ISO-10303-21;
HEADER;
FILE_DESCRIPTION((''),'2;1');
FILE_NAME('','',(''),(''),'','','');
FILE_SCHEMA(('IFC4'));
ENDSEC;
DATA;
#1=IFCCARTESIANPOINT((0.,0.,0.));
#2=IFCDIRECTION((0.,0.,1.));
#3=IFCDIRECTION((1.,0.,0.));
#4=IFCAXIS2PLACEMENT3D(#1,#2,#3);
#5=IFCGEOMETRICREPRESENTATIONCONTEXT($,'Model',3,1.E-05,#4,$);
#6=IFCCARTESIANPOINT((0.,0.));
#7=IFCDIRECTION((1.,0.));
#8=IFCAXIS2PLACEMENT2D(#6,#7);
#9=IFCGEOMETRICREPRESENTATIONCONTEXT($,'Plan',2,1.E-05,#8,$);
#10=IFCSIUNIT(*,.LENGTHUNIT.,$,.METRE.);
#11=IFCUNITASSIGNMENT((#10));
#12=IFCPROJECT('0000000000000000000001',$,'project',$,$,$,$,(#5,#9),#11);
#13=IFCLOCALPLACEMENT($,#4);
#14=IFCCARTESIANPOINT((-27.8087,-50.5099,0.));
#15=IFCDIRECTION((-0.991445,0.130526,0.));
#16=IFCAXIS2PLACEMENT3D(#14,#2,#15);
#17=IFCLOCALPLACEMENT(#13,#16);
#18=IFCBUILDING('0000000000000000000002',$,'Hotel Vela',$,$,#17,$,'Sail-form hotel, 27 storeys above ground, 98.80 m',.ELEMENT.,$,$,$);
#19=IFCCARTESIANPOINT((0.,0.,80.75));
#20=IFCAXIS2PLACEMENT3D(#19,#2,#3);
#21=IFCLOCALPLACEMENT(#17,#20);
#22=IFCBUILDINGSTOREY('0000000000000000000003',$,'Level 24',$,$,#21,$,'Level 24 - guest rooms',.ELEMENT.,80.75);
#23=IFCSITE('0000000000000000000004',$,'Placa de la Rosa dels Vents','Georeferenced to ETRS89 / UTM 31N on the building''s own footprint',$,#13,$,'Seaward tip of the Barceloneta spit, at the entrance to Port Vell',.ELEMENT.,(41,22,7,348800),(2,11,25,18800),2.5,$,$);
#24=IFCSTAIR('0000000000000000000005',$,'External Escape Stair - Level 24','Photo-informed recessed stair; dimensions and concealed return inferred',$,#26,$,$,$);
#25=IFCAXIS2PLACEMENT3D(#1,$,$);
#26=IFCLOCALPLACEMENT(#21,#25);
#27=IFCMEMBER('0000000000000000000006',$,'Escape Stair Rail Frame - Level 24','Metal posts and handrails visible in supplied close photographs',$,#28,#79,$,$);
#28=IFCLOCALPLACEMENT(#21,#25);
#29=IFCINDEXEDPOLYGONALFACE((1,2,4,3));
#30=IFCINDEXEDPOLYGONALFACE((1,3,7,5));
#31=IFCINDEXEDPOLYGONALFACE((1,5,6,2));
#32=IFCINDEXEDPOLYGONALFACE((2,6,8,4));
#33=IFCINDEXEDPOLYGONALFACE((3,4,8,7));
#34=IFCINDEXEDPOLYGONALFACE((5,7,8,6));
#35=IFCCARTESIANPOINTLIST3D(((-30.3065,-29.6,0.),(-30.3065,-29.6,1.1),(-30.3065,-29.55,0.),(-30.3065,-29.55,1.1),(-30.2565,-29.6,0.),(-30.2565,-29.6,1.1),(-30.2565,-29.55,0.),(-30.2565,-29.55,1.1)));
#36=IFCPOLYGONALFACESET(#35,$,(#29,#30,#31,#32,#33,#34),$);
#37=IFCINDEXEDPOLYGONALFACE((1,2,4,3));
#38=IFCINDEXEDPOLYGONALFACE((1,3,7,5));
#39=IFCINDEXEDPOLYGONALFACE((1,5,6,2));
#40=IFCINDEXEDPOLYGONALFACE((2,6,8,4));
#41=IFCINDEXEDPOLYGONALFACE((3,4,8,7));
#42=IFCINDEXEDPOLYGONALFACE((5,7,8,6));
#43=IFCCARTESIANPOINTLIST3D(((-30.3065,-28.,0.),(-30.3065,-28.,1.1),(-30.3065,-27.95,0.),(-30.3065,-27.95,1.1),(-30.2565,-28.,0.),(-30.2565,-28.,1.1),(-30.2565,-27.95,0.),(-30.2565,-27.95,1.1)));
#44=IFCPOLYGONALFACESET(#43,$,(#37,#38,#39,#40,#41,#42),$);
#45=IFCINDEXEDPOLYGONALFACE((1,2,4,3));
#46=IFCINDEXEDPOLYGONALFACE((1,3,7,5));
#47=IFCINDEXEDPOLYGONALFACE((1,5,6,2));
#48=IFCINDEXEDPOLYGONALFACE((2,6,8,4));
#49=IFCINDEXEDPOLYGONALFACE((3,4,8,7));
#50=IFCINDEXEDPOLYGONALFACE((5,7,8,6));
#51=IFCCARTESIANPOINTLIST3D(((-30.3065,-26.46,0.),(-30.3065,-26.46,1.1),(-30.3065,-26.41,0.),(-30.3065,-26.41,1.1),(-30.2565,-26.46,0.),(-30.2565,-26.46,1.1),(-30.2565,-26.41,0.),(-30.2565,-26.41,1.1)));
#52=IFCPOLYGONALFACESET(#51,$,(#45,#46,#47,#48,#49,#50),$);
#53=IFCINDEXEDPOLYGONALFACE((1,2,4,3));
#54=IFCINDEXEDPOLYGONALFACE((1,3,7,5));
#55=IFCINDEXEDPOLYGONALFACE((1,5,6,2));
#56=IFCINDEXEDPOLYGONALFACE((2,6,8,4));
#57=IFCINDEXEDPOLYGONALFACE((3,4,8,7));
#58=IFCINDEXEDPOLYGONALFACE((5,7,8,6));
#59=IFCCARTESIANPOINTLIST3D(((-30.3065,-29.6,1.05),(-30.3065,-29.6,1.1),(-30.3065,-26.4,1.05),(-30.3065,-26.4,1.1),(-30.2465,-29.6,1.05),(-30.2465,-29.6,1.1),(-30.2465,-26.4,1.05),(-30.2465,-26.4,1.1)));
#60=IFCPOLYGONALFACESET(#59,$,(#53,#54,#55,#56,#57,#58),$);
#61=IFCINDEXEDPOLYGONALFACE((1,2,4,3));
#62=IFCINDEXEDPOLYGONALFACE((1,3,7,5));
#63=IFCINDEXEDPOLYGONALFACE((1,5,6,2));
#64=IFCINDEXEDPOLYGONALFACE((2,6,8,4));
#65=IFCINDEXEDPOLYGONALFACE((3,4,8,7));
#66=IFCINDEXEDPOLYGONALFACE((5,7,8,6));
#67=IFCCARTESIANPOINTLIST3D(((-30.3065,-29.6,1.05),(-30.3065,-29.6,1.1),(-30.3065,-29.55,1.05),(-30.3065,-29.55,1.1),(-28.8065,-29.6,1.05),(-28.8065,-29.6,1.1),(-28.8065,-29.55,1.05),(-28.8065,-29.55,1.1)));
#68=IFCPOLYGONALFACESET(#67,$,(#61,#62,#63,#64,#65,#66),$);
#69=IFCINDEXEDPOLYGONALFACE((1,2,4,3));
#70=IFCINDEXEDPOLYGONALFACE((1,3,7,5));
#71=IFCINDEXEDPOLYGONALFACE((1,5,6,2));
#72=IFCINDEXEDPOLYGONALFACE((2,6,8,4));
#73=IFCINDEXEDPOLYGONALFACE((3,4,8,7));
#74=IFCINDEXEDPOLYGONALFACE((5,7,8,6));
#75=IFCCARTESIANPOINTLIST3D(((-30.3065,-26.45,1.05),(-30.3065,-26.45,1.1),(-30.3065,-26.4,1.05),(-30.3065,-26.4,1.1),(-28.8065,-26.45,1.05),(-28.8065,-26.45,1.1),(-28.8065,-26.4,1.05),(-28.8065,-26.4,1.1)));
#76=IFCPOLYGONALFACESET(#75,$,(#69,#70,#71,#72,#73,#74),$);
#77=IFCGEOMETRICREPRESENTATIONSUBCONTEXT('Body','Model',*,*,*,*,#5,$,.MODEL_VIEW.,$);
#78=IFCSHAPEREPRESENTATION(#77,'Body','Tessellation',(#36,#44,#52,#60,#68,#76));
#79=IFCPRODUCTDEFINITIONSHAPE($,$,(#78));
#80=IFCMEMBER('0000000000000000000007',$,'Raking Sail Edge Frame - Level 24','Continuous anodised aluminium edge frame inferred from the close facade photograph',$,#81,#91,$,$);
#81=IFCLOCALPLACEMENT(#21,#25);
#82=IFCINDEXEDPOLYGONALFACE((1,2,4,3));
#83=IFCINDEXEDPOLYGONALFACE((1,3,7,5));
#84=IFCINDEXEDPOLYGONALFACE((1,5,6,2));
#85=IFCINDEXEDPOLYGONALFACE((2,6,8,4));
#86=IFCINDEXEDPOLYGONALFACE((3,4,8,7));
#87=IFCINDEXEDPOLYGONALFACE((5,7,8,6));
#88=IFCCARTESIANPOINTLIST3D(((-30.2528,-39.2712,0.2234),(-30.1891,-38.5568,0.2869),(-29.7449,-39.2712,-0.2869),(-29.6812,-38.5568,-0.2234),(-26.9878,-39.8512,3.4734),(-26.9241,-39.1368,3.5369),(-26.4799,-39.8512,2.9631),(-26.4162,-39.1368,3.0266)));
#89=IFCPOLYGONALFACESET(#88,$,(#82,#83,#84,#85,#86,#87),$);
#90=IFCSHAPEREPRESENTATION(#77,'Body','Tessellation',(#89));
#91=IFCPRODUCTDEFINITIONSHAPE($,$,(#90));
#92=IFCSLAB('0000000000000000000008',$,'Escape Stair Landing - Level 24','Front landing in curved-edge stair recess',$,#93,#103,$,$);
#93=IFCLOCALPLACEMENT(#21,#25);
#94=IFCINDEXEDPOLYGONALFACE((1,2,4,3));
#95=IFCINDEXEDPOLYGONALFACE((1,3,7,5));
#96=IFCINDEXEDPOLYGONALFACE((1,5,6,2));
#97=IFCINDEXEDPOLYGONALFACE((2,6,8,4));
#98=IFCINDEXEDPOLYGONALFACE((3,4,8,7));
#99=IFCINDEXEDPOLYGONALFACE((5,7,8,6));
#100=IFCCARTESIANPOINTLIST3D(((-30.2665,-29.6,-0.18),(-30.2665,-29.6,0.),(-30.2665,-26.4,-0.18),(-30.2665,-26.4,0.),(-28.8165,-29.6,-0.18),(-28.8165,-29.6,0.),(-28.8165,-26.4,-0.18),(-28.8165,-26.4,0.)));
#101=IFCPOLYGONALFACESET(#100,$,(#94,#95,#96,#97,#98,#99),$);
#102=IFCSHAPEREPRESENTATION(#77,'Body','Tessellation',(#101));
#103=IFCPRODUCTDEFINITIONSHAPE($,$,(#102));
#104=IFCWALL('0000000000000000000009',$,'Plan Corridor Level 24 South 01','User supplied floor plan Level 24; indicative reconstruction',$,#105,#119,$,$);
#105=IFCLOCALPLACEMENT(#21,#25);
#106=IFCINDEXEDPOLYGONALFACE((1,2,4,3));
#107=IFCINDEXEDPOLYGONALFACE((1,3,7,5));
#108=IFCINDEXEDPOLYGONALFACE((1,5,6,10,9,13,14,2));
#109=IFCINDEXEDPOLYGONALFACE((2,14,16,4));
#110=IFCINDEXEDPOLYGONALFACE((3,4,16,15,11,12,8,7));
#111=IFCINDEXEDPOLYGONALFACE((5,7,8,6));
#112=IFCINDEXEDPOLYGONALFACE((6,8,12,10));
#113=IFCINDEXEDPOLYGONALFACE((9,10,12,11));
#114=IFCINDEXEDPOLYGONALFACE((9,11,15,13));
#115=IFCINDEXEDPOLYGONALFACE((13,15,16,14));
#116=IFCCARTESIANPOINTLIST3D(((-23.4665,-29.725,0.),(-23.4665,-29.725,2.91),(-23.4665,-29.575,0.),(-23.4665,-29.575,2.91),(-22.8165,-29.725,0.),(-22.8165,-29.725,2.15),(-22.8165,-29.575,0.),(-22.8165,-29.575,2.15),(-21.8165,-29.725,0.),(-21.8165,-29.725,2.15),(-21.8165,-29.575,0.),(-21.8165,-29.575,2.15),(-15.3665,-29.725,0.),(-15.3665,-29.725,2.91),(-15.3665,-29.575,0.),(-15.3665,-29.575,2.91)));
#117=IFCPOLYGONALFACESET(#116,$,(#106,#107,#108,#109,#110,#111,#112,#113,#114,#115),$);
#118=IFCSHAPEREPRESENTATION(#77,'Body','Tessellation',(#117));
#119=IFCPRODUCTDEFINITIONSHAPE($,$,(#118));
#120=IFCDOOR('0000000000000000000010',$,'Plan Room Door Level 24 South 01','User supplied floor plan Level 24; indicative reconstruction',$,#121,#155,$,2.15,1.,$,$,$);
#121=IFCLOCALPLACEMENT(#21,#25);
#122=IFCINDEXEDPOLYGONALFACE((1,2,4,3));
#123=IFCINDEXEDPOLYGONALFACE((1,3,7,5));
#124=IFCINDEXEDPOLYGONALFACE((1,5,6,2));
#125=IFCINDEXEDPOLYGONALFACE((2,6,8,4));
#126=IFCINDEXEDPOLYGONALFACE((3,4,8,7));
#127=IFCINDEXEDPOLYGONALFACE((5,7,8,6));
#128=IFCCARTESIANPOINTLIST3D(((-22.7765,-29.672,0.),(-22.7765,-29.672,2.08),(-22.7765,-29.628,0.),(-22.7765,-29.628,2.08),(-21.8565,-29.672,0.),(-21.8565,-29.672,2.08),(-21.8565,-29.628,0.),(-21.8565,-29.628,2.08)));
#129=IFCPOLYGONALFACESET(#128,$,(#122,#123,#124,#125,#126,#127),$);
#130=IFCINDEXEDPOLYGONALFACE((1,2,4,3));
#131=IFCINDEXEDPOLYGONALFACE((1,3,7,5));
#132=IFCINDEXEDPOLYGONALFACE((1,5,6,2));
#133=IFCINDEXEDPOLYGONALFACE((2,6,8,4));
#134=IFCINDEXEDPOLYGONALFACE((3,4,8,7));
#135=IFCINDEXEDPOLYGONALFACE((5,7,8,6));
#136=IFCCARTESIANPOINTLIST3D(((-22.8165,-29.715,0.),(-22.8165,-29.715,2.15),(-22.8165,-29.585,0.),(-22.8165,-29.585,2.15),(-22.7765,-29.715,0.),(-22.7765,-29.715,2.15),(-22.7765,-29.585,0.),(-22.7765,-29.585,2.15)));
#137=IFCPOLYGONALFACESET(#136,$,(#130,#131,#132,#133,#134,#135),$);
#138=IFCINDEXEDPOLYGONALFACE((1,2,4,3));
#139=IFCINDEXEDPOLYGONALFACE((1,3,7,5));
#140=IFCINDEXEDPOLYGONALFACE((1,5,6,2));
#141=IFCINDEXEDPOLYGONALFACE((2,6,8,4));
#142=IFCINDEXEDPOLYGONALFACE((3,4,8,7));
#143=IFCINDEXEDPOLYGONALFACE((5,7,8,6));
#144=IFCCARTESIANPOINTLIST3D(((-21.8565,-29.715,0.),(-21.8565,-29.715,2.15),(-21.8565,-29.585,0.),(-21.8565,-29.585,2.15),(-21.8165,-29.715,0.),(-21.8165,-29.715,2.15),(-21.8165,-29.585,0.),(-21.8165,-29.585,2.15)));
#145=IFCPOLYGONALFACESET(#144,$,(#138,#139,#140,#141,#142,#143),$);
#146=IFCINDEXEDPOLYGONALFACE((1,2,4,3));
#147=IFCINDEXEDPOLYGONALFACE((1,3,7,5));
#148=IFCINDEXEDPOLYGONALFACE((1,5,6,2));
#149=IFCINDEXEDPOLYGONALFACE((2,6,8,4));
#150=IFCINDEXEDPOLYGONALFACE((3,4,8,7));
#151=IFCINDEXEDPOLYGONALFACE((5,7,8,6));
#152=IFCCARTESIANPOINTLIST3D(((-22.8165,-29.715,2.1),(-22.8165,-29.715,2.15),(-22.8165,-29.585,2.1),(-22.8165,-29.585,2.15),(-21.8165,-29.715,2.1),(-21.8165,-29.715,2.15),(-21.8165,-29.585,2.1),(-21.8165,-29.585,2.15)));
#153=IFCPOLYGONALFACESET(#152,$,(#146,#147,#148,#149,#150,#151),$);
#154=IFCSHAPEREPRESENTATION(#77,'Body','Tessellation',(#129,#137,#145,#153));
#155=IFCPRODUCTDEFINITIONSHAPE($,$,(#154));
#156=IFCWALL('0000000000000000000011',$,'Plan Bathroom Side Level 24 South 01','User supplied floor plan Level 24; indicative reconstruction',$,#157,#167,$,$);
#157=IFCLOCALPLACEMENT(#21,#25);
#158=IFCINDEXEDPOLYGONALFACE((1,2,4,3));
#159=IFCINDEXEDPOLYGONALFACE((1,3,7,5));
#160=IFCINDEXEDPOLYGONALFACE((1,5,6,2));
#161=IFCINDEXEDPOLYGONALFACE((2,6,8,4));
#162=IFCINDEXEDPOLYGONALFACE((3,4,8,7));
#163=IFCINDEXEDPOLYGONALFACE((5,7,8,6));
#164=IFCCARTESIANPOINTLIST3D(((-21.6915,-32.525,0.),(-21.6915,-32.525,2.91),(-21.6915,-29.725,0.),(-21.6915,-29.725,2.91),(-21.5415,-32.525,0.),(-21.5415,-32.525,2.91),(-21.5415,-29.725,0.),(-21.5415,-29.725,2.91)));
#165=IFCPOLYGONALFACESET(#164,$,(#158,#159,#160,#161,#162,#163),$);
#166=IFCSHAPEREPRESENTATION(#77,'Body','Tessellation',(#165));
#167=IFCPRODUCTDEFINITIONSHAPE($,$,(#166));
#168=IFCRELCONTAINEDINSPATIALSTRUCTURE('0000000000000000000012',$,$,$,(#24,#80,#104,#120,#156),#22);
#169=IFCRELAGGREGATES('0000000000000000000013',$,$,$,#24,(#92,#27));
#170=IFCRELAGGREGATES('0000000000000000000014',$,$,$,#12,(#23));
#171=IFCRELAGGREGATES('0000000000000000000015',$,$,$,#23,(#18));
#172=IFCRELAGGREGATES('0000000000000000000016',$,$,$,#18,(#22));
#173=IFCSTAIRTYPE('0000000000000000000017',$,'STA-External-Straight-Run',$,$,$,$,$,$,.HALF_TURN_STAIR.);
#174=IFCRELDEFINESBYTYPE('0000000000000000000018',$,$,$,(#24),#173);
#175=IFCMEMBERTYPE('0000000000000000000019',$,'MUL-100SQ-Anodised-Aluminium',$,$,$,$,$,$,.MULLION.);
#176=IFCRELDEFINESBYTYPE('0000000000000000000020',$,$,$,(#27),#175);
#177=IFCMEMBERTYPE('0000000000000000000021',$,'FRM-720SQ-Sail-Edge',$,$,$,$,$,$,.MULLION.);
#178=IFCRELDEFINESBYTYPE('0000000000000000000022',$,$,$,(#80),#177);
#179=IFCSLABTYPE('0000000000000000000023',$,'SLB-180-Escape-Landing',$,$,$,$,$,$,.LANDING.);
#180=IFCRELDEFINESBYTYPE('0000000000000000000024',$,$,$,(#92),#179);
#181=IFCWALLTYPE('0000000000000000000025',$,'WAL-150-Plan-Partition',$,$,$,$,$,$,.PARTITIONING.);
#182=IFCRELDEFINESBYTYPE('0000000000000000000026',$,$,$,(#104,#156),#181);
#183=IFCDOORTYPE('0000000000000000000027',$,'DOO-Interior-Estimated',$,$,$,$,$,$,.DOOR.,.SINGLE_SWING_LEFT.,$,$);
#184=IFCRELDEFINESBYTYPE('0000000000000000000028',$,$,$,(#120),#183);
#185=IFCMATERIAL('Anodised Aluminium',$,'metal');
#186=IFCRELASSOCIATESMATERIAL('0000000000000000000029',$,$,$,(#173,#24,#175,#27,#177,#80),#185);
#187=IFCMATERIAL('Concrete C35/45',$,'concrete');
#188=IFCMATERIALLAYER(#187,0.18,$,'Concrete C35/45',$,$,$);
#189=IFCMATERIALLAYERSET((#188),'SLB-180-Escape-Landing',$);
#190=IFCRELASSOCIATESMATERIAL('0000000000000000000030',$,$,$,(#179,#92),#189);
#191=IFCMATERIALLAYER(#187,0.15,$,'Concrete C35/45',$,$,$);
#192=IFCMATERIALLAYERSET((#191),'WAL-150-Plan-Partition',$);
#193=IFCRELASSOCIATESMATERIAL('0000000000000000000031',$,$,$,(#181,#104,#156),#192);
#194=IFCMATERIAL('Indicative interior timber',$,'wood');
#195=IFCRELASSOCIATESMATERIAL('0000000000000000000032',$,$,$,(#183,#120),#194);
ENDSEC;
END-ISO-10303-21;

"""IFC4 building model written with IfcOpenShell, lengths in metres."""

from ifc_helpers import new_model, si_unit, frame, origin_with_axes, origin_2d_with_axis, place, context, subcontext, project, spatial, line, indexed_curve, rectangle, outline, extrude, material, layer, layer_set, layer_usage, material_profile, profile_set, profile_usage, type_object, element, fill, aggregate, save


model = new_model("IFC4")

# Units and contexts
model_context = context("Model", 3, precision=1e-05, world=origin_with_axes())
plan_context = context("Plan", 2, precision=1e-05, world=origin_2d_with_axis())
body_context = subcontext(model_context, "Body", "Model", "MODEL_VIEW")
ifc_project = project(units=[si_unit("LENGTHUNIT", "METRE")], contexts=[model_context, plan_context])

# Site, building, storey
site_placement = place(None, origin_with_axes())
site = spatial("IfcSite", under=ifc_project, at=site_placement, Name="Placa de la Rosa dels Vents", Description="Georeferenced to ETRS89 / UTM 31N on the building's own footprint", LongName="Seaward tip of the Barceloneta spit, at the entrance to Port Vell", CompositionType="ELEMENT", RefLatitude=(41, 22, 7, 348800), RefLongitude=(2, 11, 25, 18800), RefElevation=2.5)
building_placement = place(site_placement, frame((-27.8087, -50.5099, 0.0), z_axis=(0.0, 0.0, 1.0), x_axis=(-0.991445, 0.130526, 0.0)))
building = spatial("IfcBuilding", under=site, at=building_placement, Name="Hotel Vela", LongName="Sail-form hotel, 27 storeys above ground, 98.80 m", CompositionType="ELEMENT")
storey_placement = place(building_placement, frame((0.0, 0.0, 80.75), z_axis=(0.0, 0.0, 1.0), x_axis=(1.0, 0.0, 0.0)))
storey = spatial("IfcBuildingStorey", under=building, at=storey_placement, Name="Level 24", LongName="Level 24 - guest rooms", CompositionType="ELEMENT", Elevation=80.75)

# Stair, member
ifc_material_1 = material(Name="Anodised Aluminium", Category="metal")
stair_type = type_object("IfcStairType", Name="STA-External-Straight-Run", PredefinedType="HALF_TURN_STAIR", material=ifc_material_1)
stair_placement = place(storey_placement, frame((0.0, 0.0, -80.75), z_axis=(0.0, 0.0, 1.0), x_axis=(1.0, 0.0, 0.0)))
stair = element("IfcStair", 1, at=stair_placement, inside=storey, type_object=stair_type, material=ifc_material_1, Name="External Escape Stair - Level 24", Description="Photo-informed recessed stair; dimensions and concealed return inferred")
ifc_material_profile_1 = material_profile(ifc_material_1, rectangle(XDim=0.1, YDim=0.1))
ifc_profile_set_1 = profile_set([ifc_material_profile_1], Name="MUL-100SQ-Anodised-Aluminium")
ifc_profile_usage_1 = profile_usage(ifc_profile_set_1)
member_type_1 = type_object("IfcMemberType", Name="MUL-100SQ-Anodised-Aluminium", PredefinedType="MULLION", material=ifc_profile_set_1)
member_1_placement = place(stair_placement, origin_with_axes())
member_1 = element("IfcMember", 2, at=member_1_placement, type_object=member_type_1, material=ifc_profile_usage_1, Name="Escape Stair Rail Frame - Level 24", Description="Metal posts and handrails visible in supplied close photographs", context=body_context, shape_type="SweptSolid", body=[
    extrude(outline(indexed_curve([(0.0, 0.0), (0.05, 0.0), (0.05, 0.05), (0.0, 0.05)], segments=[line(1, 2, 3, 4, 1)])), frame((-30.3065, -29.6, 80.75), z_axis=(0.0, 0.0, 1.0), x_axis=(1.0, 0.0, 0.0)), (0.0, 0.0, 1.0), 1.1),
    extrude(outline(indexed_curve([(0.0, 0.0), (0.05, 0.0), (0.05, 0.05), (0.0, 0.05)], segments=[line(1, 2, 3, 4, 1)])), frame((-30.3065, -28.0, 80.75), z_axis=(0.0, 0.0, 1.0), x_axis=(1.0, 0.0, 0.0)), (0.0, 0.0, 1.0), 1.1),
    extrude(outline(indexed_curve([(0.0, 0.0), (0.05, 0.0), (0.05, 0.05), (0.0, 0.05)], segments=[line(1, 2, 3, 4, 1)])), frame((-30.3065, -26.46, 80.75), z_axis=(0.0, 0.0, 1.0), x_axis=(1.0, 0.0, 0.0)), (0.0, 0.0, 1.0), 1.1),
    extrude(outline(indexed_curve([(0.0, 0.0), (0.06, 0.0), (0.06, 3.2), (0.0, 3.2)], segments=[line(1, 2, 3, 4, 1)])), frame((-30.3065, -29.6, 81.8), z_axis=(0.0, 0.0, 1.0), x_axis=(1.0, 0.0, 0.0)), (0.0, 0.0, 1.0), 0.05),
    extrude(outline(indexed_curve([(0.0, 0.0), (1.5, 0.0), (1.5, 0.05), (0.0, 0.05)], segments=[line(1, 2, 3, 4, 1)])), frame((-30.3065, -29.6, 81.8), z_axis=(0.0, 0.0, 1.0), x_axis=(1.0, 0.0, 0.0)), (0.0, 0.0, 1.0), 0.05),
    extrude(outline(indexed_curve([(0.0, 0.0), (1.5, 0.0), (1.5, 0.05), (0.0, 0.05)], segments=[line(1, 2, 3, 4, 1)])), frame((-30.3065, -26.45, 81.8), z_axis=(0.0, 0.0, 1.0), x_axis=(1.0, 0.0, 0.0)), (0.0, 0.0, 1.0), 0.05),
])

# Member
ifc_material_profile_2 = material_profile(ifc_material_1, rectangle(XDim=0.72, YDim=0.72))
ifc_profile_set_2 = profile_set([ifc_material_profile_2], Name="FRM-720SQ-Sail-Edge")
ifc_profile_usage_2 = profile_usage(ifc_profile_set_2)
member_type_2 = type_object("IfcMemberType", Name="FRM-720SQ-Sail-Edge", PredefinedType="MULLION", material=ifc_profile_set_2)
member_2_placement = place(storey_placement, frame((-29.967, -38.914, 0.0), z_axis=(0.703182, -0.124914, 0.699951), x_axis=(0.705477, 0.0, -0.708733)))
element("IfcMember", 3, at=member_2_placement, inside=storey, type_object=member_type_2, material=ifc_profile_usage_2, Name="Raking Sail Edge Frame - Level 24", Description="Continuous anodised aluminium edge frame inferred from the close facade photograph", context=body_context, shape_type="SweptSolid", body=[
    extrude(outline(indexed_curve([(-0.36, -0.36), (0.36, -0.36), (0.36, 0.36), (-0.36, 0.36)], segments=[line(1, 2, 3, 4, 1)])), origin_with_axes(), (0.0, 0.0, 1.0), 4.6432),
])

# Slab
ifc_material_2 = material(Name="Concrete C35/45", Category="concrete")
ifc_layer_1 = layer(ifc_material_2, 0.18, Name="Concrete C35/45")
ifc_layer_set_1 = layer_set([ifc_layer_1], Name="SLB-180-Escape-Landing")
ifc_layer_usage_1 = layer_usage(ifc_layer_set_1, "AXIS3", "POSITIVE", 0.0)
slab_type = type_object("IfcSlabType", Name="SLB-180-Escape-Landing", PredefinedType="LANDING", material=ifc_layer_set_1)
slab_placement = place(stair_placement, frame((-30.2665, -29.6, 80.57), z_axis=(0.0, 0.0, 1.0), x_axis=(1.0, 0.0, 0.0)))
slab = element("IfcSlab", 4, at=slab_placement, type_object=slab_type, material=ifc_layer_usage_1, Name="Escape Stair Landing - Level 24", Description="Front landing in curved-edge stair recess", context=body_context, shape_type="SweptSolid", body=[
    extrude(outline(indexed_curve([(0.0, 0.0), (1.45, 0.0), (1.45, 3.2), (0.0, 3.2)], segments=[line(1, 2, 3, 4, 1)])), origin_with_axes(), (0.0, 0.0, 1.0), 0.18),
])

# Wall, opening, door
ifc_layer_2 = layer(ifc_material_2, 0.15, Name="Concrete C35/45")
ifc_layer_set_2 = layer_set([ifc_layer_2], Name="WAL-150-Plan-Partition")
ifc_layer_usage_2 = layer_usage(ifc_layer_set_2, "AXIS2", "POSITIVE", 0.0)
wall_type = type_object("IfcWallType", Name="WAL-150-Plan-Partition", PredefinedType="PARTITIONING", material=ifc_layer_set_2)
wall_1_placement = place(storey_placement, frame((-23.4665, -29.725, 0.0), z_axis=(0.0, 0.0, 1.0), x_axis=(1.0, 0.0, 0.0)))
wall_1 = element("IfcWall", 5, at=wall_1_placement, inside=storey, type_object=wall_type, material=ifc_layer_usage_2, Name="Plan Corridor Level 24 South 01", Description="User supplied floor plan Level 24; indicative reconstruction", context=body_context, shape_type="SweptSolid", body=[
    extrude(outline(indexed_curve([(0.0, 0.0), (8.1, 0.0), (8.1, 0.15), (0.0, 0.15)], segments=[line(1, 2, 3, 4, 1)])), origin_with_axes(), (0.0, 0.0, 1.0), 2.91),
])
opening_1_placement = place(wall_1_placement, frame((0.65, -0.085, 0.0), z_axis=(0.0, 0.0, 1.0), x_axis=(1.0, 0.0, 0.0)))
opening_1 = element("IfcOpeningElement", 6, at=opening_1_placement, cuts=wall_1, PredefinedType="OPENING", context=body_context, shape_type="SweptSolid", body=[
    extrude(outline(indexed_curve([(0.0, 0.0), (1.0, 0.0), (1.0, 0.32), (0.0, 0.32)], segments=[line(1, 2, 3, 4, 1)])), origin_with_axes(), (0.0, 0.0, 1.0), 2.15),
])
ifc_material_3 = material(Name="Indicative interior timber", Category="wood")
door_type = type_object("IfcDoorType", Name="DOO-Interior-Estimated", OperationType="SINGLE_SWING_LEFT", PredefinedType="DOOR", material=ifc_material_3)
door_1_placement = place(storey_placement, frame((0.0, 0.0, -80.75), z_axis=(0.0, 0.0, 1.0), x_axis=(1.0, 0.0, 0.0)))
door_1 = element("IfcDoor", 7, at=door_1_placement, inside=storey, type_object=door_type, material=ifc_material_3, Name="Plan Room Door Level 24 South 01", Description="User supplied floor plan Level 24; indicative reconstruction", OverallHeight=2.15, OverallWidth=1.0, context=body_context, shape_type="SweptSolid", body=[
    extrude(outline(indexed_curve([(0.0, 0.0), (0.92, 0.0), (0.92, 0.044), (0.0, 0.044)], segments=[line(1, 2, 3, 4, 1)])), frame((-22.7765, -29.672, 80.75), z_axis=(0.0, 0.0, 1.0), x_axis=(1.0, 0.0, 0.0)), (0.0, 0.0, 1.0), 2.08),
    extrude(outline(indexed_curve([(0.0, 0.0), (0.04, 0.0), (0.04, 0.13), (0.0, 0.13)], segments=[line(1, 2, 3, 4, 1)])), frame((-22.8165, -29.715, 80.75), z_axis=(0.0, 0.0, 1.0), x_axis=(1.0, 0.0, 0.0)), (0.0, 0.0, 1.0), 2.15),
    extrude(outline(indexed_curve([(0.0, 0.0), (0.04, 0.0), (0.04, 0.13), (0.0, 0.13)], segments=[line(1, 2, 3, 4, 1)])), frame((-21.8565, -29.715, 80.75), z_axis=(0.0, 0.0, 1.0), x_axis=(1.0, 0.0, 0.0)), (0.0, 0.0, 1.0), 2.15),
    extrude(outline(indexed_curve([(0.0, 0.0), (1.0, 0.0), (1.0, 0.13), (0.0, 0.13)], segments=[line(1, 2, 3, 4, 1)])), frame((-22.8165, -29.715, 82.85), z_axis=(0.0, 0.0, 1.0), x_axis=(1.0, 0.0, 0.0)), (0.0, 0.0, 1.0), 0.05),
])
fill(opening_1, door_1)

# Wall
ifc_layer_usage_3 = layer_usage(ifc_layer_set_2, "AXIS2", "POSITIVE", 0.0)
wall_2_placement = place(storey_placement, frame((-21.6915, -32.525, 0.0), z_axis=(0.0, 0.0, 1.0), x_axis=(1.0, 0.0, 0.0)))
element("IfcWall", 8, at=wall_2_placement, inside=storey, type_object=wall_type, material=ifc_layer_usage_3, Name="Plan Bathroom Side Level 24 South 01", Description="User supplied floor plan Level 24; indicative reconstruction", context=body_context, shape_type="SweptSolid", body=[
    extrude(outline(indexed_curve([(0.0, 0.0), (0.15, 0.0), (0.15, 2.8), (0.0, 2.8)], segments=[line(1, 2, 3, 4, 1)])), origin_with_axes(), (0.0, 0.0, 1.0), 2.91),
])

aggregate(stair, [slab, member_1])

save(model, "model.ifc")
